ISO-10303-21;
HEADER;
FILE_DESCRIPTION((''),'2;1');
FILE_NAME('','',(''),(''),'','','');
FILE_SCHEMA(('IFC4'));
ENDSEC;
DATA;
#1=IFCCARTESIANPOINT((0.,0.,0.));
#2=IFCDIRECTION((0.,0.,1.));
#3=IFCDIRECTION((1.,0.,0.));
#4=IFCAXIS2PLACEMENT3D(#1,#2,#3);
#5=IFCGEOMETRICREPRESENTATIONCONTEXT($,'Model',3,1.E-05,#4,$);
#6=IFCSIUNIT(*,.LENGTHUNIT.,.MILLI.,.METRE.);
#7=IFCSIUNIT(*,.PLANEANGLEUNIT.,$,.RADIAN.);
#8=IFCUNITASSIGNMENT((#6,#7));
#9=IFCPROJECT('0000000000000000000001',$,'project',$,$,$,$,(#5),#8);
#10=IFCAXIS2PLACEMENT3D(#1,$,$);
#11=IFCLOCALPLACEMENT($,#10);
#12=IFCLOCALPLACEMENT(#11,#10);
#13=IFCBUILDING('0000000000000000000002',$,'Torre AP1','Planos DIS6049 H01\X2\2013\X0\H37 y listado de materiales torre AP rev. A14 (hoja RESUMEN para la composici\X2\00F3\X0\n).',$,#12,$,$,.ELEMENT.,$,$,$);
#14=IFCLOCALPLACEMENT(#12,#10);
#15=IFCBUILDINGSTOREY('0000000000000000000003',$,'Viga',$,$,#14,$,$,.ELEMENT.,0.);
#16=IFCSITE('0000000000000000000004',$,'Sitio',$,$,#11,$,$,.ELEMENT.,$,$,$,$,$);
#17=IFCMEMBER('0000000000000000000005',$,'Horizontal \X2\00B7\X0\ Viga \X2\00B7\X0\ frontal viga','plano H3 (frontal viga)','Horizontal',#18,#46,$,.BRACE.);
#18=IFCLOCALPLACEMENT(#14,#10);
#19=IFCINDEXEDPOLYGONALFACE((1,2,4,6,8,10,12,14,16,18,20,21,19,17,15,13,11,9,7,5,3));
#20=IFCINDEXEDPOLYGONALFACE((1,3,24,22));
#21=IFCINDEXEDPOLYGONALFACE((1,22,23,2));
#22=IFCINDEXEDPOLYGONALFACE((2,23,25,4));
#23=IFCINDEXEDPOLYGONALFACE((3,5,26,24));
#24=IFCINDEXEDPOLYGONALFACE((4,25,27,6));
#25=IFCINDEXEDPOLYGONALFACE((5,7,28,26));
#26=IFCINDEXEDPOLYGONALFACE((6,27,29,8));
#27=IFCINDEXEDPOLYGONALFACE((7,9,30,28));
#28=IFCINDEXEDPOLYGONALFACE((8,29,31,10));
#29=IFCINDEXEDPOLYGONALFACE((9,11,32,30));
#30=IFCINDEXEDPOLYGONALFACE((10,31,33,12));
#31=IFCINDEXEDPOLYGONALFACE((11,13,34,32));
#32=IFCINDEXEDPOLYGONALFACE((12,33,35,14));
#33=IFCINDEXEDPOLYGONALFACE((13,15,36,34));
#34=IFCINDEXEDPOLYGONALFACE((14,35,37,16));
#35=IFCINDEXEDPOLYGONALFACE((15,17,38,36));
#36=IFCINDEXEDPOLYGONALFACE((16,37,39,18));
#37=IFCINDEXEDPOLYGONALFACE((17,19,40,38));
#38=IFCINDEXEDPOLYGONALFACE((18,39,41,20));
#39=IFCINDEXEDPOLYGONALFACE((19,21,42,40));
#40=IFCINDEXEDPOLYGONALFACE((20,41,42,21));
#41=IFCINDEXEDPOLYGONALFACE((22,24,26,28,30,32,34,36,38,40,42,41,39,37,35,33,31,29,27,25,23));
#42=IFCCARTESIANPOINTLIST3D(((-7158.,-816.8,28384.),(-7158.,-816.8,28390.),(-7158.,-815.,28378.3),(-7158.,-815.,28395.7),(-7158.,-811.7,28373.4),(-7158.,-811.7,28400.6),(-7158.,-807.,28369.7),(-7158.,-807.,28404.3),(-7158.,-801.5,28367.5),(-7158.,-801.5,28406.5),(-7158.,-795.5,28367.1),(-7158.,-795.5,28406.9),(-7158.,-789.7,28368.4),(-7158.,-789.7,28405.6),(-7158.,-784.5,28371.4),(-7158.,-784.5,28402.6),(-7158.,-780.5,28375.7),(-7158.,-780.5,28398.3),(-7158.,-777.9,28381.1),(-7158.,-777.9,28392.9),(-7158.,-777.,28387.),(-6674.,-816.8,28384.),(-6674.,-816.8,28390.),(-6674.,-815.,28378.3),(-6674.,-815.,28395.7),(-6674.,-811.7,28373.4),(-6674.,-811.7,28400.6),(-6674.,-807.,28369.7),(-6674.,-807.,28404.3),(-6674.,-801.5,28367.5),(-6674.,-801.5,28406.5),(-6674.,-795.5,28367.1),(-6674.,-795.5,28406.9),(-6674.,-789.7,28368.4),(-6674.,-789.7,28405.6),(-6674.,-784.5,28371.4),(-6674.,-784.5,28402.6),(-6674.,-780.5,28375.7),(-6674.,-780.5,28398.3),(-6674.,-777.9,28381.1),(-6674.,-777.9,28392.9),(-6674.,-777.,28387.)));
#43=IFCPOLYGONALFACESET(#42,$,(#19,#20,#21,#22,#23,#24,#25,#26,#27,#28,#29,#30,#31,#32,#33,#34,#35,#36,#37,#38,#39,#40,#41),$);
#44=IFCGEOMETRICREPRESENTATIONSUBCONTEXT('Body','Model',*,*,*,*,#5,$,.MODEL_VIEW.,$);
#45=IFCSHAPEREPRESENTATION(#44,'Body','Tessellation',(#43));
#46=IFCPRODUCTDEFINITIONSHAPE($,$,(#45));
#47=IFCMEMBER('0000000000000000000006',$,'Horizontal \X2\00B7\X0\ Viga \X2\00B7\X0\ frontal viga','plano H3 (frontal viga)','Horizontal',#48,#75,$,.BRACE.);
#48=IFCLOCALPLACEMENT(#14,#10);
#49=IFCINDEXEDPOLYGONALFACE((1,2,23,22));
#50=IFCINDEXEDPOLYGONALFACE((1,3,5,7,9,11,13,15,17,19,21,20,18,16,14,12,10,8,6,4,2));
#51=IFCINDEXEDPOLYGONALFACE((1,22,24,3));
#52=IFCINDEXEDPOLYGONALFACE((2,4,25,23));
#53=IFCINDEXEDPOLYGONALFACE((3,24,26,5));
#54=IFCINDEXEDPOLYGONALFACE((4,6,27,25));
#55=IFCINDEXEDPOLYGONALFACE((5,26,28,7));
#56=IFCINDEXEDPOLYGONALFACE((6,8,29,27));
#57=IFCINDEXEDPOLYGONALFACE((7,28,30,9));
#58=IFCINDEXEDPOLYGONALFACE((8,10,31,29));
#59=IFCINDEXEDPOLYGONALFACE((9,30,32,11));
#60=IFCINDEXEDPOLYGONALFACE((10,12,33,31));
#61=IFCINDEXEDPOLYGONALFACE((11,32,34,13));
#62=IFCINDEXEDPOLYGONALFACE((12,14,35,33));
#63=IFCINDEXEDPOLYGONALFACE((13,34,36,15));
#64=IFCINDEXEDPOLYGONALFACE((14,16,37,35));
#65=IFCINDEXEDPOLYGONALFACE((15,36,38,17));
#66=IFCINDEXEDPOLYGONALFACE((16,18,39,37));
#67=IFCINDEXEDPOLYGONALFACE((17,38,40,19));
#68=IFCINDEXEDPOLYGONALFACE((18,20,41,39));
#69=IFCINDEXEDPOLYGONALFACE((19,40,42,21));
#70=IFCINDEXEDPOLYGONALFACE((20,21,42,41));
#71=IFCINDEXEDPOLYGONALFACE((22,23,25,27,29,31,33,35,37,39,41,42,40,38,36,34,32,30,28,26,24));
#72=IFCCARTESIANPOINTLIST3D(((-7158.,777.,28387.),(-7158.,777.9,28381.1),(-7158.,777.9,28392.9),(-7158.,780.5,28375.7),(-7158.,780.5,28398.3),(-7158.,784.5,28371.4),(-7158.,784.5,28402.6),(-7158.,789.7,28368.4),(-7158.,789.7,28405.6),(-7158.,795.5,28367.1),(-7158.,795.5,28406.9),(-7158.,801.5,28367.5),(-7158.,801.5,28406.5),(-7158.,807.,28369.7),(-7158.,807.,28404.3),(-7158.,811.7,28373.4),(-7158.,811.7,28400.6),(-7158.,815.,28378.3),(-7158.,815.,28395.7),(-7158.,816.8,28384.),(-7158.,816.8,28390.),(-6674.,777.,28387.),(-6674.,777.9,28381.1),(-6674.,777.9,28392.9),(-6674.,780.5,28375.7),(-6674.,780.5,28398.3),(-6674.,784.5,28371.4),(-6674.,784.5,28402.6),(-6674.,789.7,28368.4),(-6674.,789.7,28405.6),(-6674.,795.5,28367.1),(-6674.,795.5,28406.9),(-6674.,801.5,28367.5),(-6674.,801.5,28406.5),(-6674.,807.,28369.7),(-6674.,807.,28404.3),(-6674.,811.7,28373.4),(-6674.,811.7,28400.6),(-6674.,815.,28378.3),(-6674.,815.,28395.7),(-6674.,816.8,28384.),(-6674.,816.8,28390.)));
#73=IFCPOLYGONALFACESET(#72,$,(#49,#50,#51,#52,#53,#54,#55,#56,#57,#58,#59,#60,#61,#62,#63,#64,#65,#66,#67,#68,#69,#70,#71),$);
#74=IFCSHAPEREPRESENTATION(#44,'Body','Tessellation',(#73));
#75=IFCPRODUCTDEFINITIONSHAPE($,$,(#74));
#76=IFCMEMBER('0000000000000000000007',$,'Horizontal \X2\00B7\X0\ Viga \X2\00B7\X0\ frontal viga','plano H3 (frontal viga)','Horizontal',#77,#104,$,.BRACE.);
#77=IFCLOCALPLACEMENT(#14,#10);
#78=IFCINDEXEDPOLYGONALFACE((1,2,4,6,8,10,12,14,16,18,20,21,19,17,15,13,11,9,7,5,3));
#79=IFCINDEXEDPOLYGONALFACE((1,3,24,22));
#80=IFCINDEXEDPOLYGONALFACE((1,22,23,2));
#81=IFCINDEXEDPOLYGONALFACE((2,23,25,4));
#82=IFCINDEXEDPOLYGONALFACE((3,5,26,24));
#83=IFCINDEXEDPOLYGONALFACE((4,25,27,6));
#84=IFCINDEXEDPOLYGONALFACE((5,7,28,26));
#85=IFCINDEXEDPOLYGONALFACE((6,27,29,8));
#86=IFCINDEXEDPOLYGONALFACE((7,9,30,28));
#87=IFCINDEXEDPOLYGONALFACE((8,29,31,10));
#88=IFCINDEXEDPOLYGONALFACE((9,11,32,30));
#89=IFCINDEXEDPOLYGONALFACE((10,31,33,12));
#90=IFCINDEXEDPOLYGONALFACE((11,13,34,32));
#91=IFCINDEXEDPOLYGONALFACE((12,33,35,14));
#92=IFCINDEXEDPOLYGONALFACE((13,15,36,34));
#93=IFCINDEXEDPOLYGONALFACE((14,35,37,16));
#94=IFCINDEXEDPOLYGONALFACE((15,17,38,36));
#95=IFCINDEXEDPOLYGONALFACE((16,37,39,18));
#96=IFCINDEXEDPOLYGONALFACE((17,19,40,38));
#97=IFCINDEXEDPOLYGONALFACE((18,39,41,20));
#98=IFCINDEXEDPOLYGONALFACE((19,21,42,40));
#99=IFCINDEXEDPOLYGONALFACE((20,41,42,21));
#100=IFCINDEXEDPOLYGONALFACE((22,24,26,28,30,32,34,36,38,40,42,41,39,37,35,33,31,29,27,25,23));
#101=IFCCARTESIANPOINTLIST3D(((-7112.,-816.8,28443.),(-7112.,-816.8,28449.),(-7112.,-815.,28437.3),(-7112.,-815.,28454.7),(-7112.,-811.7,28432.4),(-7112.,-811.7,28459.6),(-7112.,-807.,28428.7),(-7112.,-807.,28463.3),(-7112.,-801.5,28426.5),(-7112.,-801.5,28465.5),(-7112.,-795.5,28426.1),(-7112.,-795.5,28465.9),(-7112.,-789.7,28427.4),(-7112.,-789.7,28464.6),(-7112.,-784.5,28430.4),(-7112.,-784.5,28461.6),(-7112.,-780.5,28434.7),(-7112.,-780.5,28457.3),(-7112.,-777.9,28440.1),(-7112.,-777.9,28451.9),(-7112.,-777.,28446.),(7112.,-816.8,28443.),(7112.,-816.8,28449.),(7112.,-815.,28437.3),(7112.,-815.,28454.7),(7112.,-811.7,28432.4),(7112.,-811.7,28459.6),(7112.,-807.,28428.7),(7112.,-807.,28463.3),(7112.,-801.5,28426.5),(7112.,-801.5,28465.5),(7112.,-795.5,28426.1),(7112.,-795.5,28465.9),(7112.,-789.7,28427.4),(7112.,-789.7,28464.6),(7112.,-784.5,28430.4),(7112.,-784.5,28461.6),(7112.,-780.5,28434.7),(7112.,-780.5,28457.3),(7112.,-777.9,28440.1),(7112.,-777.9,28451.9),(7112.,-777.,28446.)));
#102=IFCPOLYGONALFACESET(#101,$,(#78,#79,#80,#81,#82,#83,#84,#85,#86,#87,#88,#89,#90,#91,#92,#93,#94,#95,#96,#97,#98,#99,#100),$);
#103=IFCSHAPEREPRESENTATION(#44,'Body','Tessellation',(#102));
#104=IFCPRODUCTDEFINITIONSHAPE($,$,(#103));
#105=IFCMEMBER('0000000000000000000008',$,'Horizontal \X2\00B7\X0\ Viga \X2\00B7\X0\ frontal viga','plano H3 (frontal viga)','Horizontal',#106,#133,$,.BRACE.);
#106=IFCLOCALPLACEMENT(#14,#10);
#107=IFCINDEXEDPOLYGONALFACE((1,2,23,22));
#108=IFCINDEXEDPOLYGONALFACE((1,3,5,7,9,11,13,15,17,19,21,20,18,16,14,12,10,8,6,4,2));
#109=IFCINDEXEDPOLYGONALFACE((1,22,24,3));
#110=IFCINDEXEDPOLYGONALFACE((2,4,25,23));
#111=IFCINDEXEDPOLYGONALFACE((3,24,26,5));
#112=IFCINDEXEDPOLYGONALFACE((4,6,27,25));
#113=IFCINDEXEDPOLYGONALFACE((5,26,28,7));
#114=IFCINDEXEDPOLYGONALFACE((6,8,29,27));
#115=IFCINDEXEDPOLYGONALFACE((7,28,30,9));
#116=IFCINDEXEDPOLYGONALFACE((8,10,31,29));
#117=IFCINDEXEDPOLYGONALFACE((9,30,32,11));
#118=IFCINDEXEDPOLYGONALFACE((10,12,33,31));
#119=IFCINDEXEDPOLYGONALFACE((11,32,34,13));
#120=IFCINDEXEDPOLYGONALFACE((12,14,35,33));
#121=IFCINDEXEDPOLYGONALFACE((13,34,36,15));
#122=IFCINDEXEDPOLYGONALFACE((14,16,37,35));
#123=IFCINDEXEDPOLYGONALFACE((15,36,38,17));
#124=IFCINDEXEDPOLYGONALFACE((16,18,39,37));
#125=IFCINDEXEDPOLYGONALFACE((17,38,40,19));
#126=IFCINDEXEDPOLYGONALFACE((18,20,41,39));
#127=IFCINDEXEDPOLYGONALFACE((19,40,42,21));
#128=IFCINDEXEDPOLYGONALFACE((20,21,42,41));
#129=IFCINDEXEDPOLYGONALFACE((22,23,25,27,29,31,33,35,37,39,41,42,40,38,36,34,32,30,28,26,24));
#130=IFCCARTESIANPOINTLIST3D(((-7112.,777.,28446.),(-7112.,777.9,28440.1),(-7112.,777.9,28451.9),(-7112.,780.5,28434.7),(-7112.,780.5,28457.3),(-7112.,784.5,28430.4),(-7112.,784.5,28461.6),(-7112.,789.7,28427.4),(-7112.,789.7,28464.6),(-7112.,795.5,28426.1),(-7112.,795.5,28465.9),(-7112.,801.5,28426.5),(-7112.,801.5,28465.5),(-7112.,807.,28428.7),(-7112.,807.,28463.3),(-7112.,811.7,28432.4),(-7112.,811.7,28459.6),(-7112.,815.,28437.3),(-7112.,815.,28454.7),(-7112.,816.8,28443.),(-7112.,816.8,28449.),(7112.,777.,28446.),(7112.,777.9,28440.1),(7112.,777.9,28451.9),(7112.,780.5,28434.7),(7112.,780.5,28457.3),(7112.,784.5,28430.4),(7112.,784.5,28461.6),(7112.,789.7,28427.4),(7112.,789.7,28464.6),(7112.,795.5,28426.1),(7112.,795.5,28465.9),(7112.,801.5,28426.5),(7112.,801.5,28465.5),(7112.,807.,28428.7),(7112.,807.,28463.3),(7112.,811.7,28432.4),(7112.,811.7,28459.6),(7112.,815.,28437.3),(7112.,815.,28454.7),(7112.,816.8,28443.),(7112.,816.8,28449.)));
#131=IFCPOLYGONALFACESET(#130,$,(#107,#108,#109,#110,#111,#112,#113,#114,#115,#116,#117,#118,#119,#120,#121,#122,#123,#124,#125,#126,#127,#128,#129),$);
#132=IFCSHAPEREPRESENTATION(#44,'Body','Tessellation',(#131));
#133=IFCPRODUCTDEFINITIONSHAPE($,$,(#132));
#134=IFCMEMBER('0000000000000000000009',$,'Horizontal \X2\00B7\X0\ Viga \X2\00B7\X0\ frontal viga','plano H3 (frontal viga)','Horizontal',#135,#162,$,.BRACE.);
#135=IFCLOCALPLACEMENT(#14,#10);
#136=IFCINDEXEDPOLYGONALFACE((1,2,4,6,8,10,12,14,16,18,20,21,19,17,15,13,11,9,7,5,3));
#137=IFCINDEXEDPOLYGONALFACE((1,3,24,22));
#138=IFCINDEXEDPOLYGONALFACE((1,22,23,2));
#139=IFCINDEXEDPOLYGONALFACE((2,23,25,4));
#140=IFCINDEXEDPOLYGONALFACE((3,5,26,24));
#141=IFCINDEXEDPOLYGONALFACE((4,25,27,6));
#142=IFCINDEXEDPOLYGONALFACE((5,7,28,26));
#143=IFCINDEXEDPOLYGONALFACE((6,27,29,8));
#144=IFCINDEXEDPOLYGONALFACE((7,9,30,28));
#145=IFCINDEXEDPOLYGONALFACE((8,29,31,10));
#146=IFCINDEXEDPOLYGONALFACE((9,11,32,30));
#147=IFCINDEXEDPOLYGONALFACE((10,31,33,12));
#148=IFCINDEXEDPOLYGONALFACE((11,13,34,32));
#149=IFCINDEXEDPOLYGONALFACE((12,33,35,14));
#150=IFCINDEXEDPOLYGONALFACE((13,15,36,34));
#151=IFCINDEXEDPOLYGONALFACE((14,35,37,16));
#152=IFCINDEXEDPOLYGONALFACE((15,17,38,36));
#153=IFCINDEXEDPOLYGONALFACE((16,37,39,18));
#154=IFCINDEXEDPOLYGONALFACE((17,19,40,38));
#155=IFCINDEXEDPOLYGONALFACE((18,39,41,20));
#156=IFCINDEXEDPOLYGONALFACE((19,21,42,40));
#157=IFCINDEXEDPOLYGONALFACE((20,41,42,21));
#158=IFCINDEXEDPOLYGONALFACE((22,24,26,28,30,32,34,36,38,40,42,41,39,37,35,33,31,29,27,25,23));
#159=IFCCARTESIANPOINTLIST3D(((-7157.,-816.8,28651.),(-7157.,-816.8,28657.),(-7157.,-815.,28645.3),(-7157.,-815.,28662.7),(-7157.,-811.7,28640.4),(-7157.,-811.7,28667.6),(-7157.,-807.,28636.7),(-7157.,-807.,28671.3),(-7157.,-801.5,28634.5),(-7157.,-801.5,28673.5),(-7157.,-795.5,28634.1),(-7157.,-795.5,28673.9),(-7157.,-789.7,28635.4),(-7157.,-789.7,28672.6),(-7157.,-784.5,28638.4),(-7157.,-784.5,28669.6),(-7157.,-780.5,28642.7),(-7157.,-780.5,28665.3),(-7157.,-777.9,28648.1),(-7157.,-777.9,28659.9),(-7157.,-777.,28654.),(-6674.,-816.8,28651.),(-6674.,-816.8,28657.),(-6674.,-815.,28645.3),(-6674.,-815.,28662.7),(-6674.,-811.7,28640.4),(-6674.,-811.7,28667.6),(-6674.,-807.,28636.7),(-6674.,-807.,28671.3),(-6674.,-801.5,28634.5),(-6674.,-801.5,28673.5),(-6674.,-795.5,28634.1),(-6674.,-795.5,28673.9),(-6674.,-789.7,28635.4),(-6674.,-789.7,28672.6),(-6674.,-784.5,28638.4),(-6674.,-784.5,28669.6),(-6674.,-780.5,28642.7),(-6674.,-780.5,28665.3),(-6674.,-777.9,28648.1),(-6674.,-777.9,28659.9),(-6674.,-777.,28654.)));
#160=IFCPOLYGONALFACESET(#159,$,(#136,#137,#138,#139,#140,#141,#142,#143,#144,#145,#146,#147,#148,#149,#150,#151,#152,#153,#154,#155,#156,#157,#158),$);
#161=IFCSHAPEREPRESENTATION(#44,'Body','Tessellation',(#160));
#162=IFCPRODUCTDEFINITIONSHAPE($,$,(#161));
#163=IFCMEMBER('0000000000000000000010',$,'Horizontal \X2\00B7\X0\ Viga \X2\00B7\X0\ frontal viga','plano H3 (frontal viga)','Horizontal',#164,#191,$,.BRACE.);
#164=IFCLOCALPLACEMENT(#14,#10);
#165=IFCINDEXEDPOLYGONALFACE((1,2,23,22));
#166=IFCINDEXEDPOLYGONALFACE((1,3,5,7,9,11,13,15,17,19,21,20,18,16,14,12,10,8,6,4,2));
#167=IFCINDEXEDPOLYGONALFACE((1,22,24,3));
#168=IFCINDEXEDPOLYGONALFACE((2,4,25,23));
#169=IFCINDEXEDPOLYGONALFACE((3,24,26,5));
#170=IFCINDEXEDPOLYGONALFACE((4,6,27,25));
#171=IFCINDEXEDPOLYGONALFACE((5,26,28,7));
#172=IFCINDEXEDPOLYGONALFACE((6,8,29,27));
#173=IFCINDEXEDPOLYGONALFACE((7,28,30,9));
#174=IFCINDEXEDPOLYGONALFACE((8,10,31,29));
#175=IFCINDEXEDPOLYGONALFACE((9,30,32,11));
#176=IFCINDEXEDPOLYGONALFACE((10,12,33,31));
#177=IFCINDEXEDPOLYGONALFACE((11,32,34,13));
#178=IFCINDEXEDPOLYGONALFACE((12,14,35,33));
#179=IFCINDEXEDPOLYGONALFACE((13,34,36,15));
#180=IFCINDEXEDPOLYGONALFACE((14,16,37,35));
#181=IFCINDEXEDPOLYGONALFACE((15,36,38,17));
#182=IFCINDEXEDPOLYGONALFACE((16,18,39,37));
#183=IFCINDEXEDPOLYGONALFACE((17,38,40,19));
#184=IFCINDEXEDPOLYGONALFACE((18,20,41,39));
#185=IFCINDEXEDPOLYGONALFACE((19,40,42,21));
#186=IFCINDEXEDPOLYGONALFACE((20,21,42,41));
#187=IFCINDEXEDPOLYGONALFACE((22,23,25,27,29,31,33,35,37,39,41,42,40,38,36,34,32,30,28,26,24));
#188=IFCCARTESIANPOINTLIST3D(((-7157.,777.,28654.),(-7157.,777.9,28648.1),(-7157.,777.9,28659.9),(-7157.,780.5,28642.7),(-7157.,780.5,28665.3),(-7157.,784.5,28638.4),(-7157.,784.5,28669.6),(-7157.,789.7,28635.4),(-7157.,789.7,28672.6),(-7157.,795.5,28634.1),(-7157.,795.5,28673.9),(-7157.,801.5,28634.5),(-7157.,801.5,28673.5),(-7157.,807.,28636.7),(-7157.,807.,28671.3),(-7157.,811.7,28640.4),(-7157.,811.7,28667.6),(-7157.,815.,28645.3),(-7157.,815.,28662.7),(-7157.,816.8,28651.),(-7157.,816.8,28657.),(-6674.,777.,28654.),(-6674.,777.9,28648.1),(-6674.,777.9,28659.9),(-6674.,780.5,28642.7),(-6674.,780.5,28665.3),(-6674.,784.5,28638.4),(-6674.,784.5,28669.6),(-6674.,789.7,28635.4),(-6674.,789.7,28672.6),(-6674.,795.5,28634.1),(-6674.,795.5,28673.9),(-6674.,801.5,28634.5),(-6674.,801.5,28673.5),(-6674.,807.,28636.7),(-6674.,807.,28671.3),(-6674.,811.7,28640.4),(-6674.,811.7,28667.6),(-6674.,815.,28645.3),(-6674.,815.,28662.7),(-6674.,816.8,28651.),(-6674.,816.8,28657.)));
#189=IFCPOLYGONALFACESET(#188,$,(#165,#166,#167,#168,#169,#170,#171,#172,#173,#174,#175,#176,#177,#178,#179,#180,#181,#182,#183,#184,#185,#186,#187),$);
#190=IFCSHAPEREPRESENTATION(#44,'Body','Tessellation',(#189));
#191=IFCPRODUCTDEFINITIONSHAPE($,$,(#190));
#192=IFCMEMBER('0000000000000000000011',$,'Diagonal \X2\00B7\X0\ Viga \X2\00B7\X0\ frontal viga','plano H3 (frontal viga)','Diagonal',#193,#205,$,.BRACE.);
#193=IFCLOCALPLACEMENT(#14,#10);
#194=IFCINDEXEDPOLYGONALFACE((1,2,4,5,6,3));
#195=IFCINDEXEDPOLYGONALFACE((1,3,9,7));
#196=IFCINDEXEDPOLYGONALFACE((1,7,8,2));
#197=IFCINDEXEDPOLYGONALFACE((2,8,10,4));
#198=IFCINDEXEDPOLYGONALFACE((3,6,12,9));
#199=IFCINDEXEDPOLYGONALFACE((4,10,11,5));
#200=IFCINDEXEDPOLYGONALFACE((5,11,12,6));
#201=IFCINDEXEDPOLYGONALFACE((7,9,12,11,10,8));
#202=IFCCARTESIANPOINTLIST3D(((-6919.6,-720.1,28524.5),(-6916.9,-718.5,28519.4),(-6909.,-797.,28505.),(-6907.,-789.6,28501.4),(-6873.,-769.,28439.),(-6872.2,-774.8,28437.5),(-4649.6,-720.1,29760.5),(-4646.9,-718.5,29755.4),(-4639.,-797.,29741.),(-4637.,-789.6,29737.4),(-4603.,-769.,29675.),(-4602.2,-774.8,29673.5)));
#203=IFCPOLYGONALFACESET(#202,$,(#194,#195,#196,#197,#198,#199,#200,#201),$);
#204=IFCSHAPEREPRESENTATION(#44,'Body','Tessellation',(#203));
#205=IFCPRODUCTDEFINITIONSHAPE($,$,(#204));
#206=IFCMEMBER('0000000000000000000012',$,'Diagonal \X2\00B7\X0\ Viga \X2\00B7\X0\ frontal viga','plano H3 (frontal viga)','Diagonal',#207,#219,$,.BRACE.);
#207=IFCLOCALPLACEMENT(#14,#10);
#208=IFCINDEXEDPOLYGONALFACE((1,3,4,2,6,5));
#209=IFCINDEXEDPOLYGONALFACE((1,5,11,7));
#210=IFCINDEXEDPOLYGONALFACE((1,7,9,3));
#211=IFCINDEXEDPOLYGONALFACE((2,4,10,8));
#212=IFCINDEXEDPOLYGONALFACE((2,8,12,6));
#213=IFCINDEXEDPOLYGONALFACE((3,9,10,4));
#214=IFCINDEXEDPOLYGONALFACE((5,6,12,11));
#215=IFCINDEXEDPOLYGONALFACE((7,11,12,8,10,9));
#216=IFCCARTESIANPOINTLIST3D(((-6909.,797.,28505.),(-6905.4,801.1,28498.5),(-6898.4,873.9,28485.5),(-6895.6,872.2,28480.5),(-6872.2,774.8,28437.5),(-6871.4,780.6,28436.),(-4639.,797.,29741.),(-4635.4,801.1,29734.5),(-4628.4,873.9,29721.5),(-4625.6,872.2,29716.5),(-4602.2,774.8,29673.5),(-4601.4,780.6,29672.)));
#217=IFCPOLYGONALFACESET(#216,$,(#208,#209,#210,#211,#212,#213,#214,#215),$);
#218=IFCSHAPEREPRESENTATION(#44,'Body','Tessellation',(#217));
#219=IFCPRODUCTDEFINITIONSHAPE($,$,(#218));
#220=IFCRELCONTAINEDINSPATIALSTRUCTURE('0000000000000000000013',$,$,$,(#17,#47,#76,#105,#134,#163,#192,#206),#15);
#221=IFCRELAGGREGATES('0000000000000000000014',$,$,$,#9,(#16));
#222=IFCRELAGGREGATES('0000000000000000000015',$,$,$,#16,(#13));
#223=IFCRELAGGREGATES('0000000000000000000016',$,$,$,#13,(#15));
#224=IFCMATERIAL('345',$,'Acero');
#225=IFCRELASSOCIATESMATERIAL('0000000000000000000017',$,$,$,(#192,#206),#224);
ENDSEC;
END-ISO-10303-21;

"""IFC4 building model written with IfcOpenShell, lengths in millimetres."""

from ifc_helpers import new_model, si_unit, frame, frame_2d, origin, origin_with_axes, place, context, subcontext, project, spatial, circle, l_section, extrude, material, element, save


model = new_model("IFC4")

# Units and contexts
model_context = context("Model", 3, precision=1e-05, world=origin_with_axes())
body_context = subcontext(model_context, "Body", "Model", "MODEL_VIEW")
ifc_project = project(units=[si_unit("LENGTHUNIT", "METRE", prefix="MILLI"), si_unit("PLANEANGLEUNIT", "RADIAN")], contexts=[model_context])

# Site, building, storey
site_placement = place(None, origin())
site = spatial("IfcSite", under=ifc_project, at=site_placement, Name="Sitio", CompositionType="ELEMENT")
building_placement = place(site_placement, origin())
building = spatial("IfcBuilding", under=site, at=building_placement, Name="Torre AP1", Description="Planos DIS6049 H01–H37 y listado de materiales torre AP rev. A14 (hoja RESUMEN para la composición).", CompositionType="ELEMENT")
storey_placement = place(building_placement, origin())
storey = spatial("IfcBuildingStorey", under=building, at=storey_placement, Name="Viga", CompositionType="ELEMENT", Elevation=0.0)

# Members
for number, where, z_axis, x_axis, name in (
    (1, (-7158.0, -797.0, 28387.0), (1.0, 0.0, 0.0), (0.0, 1.0, 0.0), "Horizontal · Viga · frontal viga"),
    (2, (-7158.0, 797.0, 28387.0), (1.0, 0.0, 0.0), (0.0, -1.0, 0.0), "Horizontal · Viga · frontal viga"),
):
    element("IfcMember", number, at=place(storey_placement, frame(where, z_axis=z_axis, x_axis=x_axis)), inside=storey, Name=name, Description="plano H3 (frontal viga)", ObjectType="Horizontal", PredefinedType="BRACE", context=body_context, shape_type="SweptSolid", body=[
        extrude(circle(Radius=20.0), None, (0.0, 0.0, 1.0), 484.0),
    ])
for number, where, z_axis, x_axis, name in (
    (3, (-7112.0, -797.0, 28446.0), (1.0, 0.0, 0.0), (0.0, 1.0, 0.0), "Horizontal · Viga · frontal viga"),
    (4, (-7112.0, 797.0, 28446.0), (1.0, 0.0, 0.0), (0.0, -1.0, 0.0), "Horizontal · Viga · frontal viga"),
):
    element("IfcMember", number, at=place(storey_placement, frame(where, z_axis=z_axis, x_axis=x_axis)), inside=storey, Name=name, Description="plano H3 (frontal viga)", ObjectType="Horizontal", PredefinedType="BRACE", context=body_context, shape_type="SweptSolid", body=[
        extrude(circle(Radius=20.0), None, (0.0, 0.0, 1.0), 14224.0),
    ])
for number, where, z_axis, x_axis, name in (
    (5, (-7157.0, -797.0, 28654.0), (1.0, 0.0, 0.0), (0.0, 1.0, 0.0), "Horizontal · Viga · frontal viga"),
    (6, (-7157.0, 797.0, 28654.0), (1.0, 0.0, 0.0), (0.0, -1.0, 0.0), "Horizontal · Viga · frontal viga"),
):
    element("IfcMember", number, at=place(storey_placement, frame(where, z_axis=z_axis, x_axis=x_axis)), inside=storey, Name=name, Description="plano H3 (frontal viga)", ObjectType="Horizontal", PredefinedType="BRACE", context=body_context, shape_type="SweptSolid", body=[
        extrude(circle(Radius=20.0), None, (0.0, 0.0, 1.0), 483.0),
    ])
ifc_material_1 = material(Name="345", Category="Acero")
for number, where, z_axis, x_axis, name in (
    (7, (-6909.0, -797.0, 28505.0), (0.87825, 0.0, 0.478201), (0.459444, 0.277327, -0.843801), "Diagonal · Viga · frontal viga"),
    (8, (-6909.0, 797.0, 28505.0), (0.87825, 0.0, 0.478201), (0.459444, -0.277327, -0.843801), "Diagonal · Viga · frontal viga"),
):
    element("IfcMember", number, at=place(storey_placement, frame(where, z_axis=z_axis, x_axis=x_axis)), inside=storey, material=ifc_material_1, Name=name, Description="plano H3 (frontal viga)", ObjectType="Diagonal", PredefinedType="BRACE", context=body_context, shape_type="SweptSolid", body=[
        extrude(l_section(Depth=80.0, Width=80.0, Thickness=6.0, at=frame_2d((40.0, 40.0))), None, (0.0, 0.0, 1.0), 2584.7),
    ])

save(model, "model.ifc")
